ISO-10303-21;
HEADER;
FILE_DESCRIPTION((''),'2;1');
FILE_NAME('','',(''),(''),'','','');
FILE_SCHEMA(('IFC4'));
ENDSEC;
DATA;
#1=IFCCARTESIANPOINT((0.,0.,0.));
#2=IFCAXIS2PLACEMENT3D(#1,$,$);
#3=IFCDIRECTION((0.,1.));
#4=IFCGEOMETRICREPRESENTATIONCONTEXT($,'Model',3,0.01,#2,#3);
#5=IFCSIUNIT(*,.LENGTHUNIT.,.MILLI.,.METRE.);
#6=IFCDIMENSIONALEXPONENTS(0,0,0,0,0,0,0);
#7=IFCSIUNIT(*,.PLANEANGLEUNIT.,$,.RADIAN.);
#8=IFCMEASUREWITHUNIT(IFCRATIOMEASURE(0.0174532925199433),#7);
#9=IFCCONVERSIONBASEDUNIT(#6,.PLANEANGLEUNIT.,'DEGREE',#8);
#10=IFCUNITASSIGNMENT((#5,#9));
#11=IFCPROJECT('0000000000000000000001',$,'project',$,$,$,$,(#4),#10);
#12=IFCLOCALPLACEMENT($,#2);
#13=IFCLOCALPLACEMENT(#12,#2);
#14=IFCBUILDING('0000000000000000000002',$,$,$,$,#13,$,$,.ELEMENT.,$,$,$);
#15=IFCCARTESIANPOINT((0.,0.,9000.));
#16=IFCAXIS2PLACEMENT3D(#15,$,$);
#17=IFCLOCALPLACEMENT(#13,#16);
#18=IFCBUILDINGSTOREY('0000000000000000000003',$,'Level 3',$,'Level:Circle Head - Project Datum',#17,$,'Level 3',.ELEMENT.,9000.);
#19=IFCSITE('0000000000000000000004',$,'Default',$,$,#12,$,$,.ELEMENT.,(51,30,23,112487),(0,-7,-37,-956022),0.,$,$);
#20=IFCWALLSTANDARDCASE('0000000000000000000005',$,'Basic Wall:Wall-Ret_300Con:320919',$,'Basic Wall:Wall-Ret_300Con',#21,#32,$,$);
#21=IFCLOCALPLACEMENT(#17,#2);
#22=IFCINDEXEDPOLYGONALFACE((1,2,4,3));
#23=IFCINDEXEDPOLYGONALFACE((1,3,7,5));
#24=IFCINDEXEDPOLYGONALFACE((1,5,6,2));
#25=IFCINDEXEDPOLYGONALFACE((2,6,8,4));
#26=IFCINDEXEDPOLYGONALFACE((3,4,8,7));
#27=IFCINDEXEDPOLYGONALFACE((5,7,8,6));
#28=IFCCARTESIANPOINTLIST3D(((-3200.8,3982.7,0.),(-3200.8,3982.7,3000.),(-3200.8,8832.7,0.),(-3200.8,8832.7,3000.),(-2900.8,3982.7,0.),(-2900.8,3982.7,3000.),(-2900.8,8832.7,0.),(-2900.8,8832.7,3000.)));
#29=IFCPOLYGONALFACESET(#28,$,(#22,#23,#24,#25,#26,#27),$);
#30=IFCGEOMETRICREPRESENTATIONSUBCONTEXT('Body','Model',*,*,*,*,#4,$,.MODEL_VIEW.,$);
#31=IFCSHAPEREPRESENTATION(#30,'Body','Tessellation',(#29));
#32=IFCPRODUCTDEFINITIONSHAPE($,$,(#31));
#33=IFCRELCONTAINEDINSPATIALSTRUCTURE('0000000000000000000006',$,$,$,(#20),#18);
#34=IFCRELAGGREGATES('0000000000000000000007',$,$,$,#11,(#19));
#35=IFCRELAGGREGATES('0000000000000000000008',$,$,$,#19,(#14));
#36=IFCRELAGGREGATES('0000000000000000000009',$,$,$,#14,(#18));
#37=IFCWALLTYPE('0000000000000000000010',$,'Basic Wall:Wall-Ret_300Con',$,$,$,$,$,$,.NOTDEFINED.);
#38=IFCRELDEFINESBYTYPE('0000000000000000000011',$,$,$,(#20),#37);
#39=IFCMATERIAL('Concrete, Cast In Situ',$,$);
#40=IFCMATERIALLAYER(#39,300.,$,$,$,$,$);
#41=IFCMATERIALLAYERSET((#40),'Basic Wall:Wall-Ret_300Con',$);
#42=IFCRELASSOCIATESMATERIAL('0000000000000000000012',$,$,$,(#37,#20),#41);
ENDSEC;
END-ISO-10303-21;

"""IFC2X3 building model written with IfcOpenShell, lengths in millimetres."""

from ifc_helpers import new_model, entity, si_unit, converted_unit, direction, frame, frame_2d, origin, place, context, subcontext, project, spatial, rectangle, extrude, material, layer, layer_set, layer_usage, type_object, element, save


model = new_model("IFC2X3")

# Units and contexts
model_context = context("Model", 3, precision=0.01, world=origin(), true_north=direction((0.0, 1.0)))
body_context = subcontext(model_context, "Body", "Model", "MODEL_VIEW")
ifc_project = project(units=[si_unit("LENGTHUNIT", "METRE", prefix="MILLI"), converted_unit("PLANEANGLEUNIT", "DEGREE", entity("IfcRatioMeasure", 0.0174532925199433), si_unit("PLANEANGLEUNIT", "RADIAN"), dimensions=[0, 0, 0, 0, 0, 0, 0])], contexts=[model_context])

# Site, building, storey
site_placement = place(None, origin())
site = spatial("IfcSite", under=ifc_project, at=site_placement, Name="Default", CompositionType="ELEMENT", RefLatitude=(51, 30, 23, 112487), RefLongitude=(0, -7, -37, -956022), RefElevation=0.0)
building_placement = place(site_placement, origin())
building = spatial("IfcBuilding", under=site, at=building_placement, CompositionType="ELEMENT")
storey_placement = place(building_placement, frame((0.0, 0.0, 9000.0)))
storey = spatial("IfcBuildingStorey", under=building, at=storey_placement, Name="Level 3", ObjectType="Level:Circle Head - Project Datum", LongName="Level 3", CompositionType="ELEMENT", Elevation=9000.0)

# Wall
ifc_material_1 = material(Name="Concrete, Cast In Situ")
ifc_layer_1 = layer(ifc_material_1, 300.0)
ifc_layer_set_1 = layer_set([ifc_layer_1], Name="Basic Wall:Wall-Ret_300Con")
wall_type = type_object("IfcWallType", Name="Basic Wall:Wall-Ret_300Con", PredefinedType="NOTDEFINED", material=ifc_layer_set_1)
ifc_layer_usage_1 = layer_usage(ifc_layer_set_1, "AXIS2", "NEGATIVE", 150.0)
wall_1_placement = place(storey_placement, frame((-3050.8, 3982.7, 0.0), z_axis=(0.0, 0.0, 1.0), x_axis=(0.0, 1.0, 0.0)))
element("IfcWallStandardCase", 1, at=wall_1_placement, inside=storey, type_object=wall_type, material=ifc_layer_usage_1, Name="Basic Wall:Wall-Ret_300Con:320919", ObjectType="Basic Wall:Wall-Ret_300Con", context=body_context, shape_type="SweptSolid", body=[
    extrude(rectangle(XDim=4850.0, YDim=300.0, at=frame_2d((2425.0, 0.0), x_axis=(-1.0, 0.0))), origin(), (0.0, 0.0, 1.0), 3000.0),
])

save(model, "model.ifc")
